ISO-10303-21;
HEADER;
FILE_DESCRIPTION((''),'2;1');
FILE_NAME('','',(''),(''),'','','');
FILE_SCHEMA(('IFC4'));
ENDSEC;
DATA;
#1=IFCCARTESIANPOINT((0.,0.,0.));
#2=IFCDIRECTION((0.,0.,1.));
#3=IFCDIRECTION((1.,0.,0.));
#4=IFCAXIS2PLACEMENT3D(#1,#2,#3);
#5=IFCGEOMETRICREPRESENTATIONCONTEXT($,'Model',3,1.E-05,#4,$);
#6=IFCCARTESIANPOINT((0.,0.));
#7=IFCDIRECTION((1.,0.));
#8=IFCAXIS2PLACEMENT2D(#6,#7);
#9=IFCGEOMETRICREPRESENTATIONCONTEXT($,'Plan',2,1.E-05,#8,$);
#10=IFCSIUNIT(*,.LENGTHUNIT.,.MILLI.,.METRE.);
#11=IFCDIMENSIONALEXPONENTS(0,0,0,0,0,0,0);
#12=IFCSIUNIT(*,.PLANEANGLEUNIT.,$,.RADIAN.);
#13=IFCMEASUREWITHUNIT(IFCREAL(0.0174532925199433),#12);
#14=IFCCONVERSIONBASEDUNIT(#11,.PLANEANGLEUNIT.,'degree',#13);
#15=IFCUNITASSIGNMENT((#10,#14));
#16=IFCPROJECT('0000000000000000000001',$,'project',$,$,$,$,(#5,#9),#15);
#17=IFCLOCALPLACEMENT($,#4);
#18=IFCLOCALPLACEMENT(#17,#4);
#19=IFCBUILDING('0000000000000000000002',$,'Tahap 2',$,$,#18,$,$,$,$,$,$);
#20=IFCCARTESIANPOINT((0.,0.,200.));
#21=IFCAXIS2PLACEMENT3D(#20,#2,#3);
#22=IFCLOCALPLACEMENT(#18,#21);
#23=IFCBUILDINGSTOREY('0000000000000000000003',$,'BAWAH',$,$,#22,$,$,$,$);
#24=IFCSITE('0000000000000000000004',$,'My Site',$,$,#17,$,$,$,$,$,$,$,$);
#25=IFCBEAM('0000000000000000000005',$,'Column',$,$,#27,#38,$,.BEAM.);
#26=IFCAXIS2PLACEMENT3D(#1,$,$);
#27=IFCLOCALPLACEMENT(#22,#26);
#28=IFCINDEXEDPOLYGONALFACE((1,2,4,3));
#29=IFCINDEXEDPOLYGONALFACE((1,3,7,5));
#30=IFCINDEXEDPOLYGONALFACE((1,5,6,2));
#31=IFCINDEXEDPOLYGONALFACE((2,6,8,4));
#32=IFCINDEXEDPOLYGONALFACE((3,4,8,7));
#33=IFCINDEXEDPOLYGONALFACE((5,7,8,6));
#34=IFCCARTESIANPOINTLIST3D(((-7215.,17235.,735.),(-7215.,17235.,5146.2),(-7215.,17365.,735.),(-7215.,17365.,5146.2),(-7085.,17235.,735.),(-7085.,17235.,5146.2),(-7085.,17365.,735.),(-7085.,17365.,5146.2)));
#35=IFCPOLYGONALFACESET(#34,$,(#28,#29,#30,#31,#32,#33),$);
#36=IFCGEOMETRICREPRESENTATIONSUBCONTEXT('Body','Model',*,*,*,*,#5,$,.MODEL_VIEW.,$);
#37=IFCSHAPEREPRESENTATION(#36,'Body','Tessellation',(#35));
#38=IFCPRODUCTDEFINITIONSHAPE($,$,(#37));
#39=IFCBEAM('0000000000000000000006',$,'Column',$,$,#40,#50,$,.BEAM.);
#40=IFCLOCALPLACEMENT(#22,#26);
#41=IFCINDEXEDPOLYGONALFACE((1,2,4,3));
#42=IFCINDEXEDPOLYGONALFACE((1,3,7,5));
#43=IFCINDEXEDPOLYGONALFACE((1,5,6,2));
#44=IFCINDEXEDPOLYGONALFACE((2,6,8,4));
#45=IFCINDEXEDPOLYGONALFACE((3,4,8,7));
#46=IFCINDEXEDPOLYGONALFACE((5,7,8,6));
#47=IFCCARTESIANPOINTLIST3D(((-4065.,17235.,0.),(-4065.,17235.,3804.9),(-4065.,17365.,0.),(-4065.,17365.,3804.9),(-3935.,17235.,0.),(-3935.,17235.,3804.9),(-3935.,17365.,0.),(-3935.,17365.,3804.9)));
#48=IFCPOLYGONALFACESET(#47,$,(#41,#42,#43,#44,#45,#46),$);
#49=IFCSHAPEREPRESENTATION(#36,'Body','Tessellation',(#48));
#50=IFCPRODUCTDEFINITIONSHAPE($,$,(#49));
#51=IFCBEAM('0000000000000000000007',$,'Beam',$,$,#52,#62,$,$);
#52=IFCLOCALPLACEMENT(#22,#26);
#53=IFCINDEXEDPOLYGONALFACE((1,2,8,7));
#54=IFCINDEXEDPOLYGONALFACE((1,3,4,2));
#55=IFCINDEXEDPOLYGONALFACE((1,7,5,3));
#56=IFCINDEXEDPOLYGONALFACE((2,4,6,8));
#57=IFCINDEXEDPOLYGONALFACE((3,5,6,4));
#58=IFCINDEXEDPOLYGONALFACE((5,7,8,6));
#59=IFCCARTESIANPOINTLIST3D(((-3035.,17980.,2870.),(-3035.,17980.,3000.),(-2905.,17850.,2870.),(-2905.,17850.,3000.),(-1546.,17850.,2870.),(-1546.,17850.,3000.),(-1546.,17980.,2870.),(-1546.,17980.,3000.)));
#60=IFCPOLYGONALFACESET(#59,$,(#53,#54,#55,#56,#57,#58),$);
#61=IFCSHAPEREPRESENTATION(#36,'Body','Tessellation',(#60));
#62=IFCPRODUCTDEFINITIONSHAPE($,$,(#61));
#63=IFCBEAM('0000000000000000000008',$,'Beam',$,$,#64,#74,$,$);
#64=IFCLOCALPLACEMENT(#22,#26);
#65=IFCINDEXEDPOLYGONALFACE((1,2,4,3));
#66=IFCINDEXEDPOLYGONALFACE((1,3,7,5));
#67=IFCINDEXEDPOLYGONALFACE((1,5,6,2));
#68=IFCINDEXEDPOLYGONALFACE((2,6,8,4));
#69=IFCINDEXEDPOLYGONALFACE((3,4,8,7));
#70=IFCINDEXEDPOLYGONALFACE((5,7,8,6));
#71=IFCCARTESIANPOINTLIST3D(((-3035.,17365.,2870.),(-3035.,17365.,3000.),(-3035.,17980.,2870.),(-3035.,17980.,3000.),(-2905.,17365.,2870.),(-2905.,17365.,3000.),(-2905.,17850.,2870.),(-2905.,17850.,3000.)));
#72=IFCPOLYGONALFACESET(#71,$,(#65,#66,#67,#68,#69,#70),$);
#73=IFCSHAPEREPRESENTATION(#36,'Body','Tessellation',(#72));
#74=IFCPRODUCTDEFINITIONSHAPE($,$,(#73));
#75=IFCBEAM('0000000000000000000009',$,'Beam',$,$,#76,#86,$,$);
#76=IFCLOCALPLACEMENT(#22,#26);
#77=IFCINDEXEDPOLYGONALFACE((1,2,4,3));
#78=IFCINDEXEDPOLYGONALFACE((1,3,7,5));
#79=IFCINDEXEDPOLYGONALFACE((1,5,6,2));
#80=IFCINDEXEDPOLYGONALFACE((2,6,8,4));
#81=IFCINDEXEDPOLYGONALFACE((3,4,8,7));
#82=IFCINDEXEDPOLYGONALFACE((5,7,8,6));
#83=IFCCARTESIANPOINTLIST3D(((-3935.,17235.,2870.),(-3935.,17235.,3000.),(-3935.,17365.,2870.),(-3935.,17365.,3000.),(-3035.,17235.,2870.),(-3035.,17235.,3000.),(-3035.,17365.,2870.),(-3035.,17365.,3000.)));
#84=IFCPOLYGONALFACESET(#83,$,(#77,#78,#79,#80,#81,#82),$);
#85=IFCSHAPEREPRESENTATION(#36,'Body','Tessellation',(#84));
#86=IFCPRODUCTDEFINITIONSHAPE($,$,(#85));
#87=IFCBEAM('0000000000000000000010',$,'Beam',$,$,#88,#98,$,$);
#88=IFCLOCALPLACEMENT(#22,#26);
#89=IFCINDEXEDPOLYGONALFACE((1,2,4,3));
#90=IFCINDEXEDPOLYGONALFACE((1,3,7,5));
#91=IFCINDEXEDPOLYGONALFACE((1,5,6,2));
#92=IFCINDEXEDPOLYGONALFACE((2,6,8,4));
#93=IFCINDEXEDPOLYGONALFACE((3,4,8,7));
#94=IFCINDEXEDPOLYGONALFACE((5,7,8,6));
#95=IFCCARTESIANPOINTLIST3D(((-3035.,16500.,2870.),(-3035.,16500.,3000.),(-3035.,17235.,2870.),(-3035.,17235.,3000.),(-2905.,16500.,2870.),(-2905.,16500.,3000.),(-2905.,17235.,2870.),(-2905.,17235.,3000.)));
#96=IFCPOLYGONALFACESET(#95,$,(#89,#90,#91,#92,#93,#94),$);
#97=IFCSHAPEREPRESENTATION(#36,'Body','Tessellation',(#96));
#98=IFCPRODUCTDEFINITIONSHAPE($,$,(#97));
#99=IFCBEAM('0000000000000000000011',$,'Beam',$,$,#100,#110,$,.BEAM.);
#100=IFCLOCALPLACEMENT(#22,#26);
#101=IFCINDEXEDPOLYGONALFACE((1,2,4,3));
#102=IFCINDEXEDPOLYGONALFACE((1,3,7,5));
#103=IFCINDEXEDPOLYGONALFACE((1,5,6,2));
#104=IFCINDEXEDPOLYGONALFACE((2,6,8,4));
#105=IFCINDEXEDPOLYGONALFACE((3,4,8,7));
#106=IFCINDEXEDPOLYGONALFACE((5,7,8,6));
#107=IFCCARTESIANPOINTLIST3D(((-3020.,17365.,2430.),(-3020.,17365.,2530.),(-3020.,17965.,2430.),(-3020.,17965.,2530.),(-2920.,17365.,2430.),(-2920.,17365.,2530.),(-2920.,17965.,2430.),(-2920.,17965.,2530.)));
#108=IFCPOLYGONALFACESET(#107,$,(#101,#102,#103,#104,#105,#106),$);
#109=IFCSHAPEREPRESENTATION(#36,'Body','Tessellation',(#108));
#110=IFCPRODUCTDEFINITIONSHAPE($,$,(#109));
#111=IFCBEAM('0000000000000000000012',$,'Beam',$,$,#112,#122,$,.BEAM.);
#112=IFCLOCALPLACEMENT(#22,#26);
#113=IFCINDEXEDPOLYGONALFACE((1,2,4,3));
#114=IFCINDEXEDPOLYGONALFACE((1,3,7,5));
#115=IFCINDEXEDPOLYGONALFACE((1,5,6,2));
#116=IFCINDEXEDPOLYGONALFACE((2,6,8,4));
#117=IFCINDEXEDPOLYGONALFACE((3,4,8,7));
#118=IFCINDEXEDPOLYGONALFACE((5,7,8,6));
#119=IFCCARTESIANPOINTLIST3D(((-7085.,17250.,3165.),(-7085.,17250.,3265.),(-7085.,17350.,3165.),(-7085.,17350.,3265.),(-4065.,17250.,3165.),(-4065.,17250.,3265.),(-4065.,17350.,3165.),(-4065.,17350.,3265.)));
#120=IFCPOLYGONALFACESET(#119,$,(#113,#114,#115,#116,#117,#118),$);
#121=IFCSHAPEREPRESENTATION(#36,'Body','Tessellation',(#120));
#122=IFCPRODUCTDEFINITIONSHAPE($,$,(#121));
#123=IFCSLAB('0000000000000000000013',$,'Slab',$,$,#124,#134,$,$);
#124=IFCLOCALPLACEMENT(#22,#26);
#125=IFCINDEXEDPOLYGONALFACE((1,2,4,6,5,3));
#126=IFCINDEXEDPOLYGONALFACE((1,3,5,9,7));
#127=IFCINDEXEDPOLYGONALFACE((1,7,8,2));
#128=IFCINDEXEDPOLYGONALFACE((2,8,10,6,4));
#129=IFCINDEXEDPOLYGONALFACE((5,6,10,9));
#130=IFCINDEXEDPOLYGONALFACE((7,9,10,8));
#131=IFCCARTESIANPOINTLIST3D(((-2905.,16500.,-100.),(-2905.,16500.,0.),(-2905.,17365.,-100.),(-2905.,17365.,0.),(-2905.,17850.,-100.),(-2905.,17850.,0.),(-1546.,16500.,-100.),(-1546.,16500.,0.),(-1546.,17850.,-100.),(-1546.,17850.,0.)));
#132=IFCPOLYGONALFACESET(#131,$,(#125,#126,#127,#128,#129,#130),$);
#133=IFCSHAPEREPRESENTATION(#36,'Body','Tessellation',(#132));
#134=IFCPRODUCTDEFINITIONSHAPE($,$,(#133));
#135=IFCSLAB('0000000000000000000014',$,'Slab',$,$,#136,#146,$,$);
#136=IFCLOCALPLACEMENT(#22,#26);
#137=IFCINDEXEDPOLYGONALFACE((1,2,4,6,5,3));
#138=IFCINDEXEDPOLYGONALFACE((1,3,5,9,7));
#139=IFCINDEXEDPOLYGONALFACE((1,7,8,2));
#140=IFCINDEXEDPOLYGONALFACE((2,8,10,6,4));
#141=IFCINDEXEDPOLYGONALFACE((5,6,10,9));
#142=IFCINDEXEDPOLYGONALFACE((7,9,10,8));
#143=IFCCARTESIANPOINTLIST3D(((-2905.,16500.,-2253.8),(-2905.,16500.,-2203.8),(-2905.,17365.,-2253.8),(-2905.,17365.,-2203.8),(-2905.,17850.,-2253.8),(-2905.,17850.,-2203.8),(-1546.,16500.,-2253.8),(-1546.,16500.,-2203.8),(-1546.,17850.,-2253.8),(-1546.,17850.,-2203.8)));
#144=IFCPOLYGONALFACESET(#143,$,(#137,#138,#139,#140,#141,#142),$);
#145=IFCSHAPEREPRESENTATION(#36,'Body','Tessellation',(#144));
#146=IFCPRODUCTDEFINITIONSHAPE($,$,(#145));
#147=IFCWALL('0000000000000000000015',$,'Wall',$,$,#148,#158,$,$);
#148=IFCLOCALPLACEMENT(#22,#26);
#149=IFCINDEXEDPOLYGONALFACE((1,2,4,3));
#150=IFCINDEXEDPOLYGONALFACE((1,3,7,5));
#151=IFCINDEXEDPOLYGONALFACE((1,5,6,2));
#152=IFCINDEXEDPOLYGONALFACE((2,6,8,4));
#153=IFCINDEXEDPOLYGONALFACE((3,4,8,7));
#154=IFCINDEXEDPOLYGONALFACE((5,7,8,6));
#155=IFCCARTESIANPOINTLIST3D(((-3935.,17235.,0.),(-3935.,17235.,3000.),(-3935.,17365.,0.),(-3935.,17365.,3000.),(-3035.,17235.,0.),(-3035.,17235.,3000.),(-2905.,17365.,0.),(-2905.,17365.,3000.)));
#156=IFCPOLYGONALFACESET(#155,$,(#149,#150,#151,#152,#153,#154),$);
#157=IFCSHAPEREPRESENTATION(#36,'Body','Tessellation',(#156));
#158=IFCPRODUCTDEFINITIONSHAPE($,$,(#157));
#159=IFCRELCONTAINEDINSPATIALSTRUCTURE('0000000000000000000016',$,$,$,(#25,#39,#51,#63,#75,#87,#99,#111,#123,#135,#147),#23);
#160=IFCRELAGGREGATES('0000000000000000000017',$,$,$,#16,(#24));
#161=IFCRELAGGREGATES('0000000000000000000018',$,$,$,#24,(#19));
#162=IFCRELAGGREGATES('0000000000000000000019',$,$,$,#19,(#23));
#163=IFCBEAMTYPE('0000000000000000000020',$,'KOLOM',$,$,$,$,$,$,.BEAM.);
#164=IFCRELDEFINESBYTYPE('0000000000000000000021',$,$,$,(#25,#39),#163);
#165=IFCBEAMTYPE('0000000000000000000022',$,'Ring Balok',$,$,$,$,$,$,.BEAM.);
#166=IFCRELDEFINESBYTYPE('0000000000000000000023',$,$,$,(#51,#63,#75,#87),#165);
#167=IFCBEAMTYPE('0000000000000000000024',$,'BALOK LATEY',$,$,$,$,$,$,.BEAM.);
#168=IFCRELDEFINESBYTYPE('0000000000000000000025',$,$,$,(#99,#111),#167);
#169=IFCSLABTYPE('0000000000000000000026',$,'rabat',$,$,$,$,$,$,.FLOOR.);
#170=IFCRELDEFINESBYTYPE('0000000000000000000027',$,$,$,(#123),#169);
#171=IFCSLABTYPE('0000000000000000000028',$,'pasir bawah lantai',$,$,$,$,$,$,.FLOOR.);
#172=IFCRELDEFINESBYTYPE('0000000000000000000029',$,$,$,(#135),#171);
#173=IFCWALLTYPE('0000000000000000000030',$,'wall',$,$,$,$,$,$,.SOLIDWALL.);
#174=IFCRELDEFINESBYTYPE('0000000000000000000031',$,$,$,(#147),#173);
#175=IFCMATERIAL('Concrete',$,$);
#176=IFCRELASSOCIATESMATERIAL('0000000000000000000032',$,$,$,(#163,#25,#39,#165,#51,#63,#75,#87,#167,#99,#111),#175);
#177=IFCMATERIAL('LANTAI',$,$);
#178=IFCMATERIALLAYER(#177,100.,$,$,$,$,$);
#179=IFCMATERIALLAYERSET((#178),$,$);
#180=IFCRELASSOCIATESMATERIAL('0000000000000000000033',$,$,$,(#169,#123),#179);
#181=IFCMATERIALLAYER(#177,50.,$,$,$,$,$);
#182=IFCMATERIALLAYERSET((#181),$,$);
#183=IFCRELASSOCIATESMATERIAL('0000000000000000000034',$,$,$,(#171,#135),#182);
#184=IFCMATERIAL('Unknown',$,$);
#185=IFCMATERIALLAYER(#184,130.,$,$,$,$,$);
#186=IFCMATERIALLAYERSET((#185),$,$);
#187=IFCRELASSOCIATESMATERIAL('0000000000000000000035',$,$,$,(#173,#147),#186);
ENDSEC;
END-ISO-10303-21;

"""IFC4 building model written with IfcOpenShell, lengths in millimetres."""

from ifc_helpers import new_model, entity, si_unit, converted_unit, frame, origin_with_axes, origin_2d_with_axis, place, context, subcontext, project, spatial, line, indexed_curve, rectangle, outline, extrude, clip, halfspace, material, layer, layer_set, layer_usage, material_profile, profile_set, profile_usage, type_object, element, save


model = new_model("IFC4")

# Units and contexts
model_context = context("Model", 3, precision=1e-05, world=origin_with_axes())
plan_context = context("Plan", 2, precision=1e-05, world=origin_2d_with_axis())
body_context = subcontext(model_context, "Body", "Model", "MODEL_VIEW")
ifc_project = project(units=[si_unit("LENGTHUNIT", "METRE", prefix="MILLI"), converted_unit("PLANEANGLEUNIT", "degree", entity("IfcReal", 0.0174532925199433), si_unit("PLANEANGLEUNIT", "RADIAN"), dimensions=[0, 0, 0, 0, 0, 0, 0])], contexts=[model_context, plan_context])

# Site, building, storey
site_placement = place(None, origin_with_axes())
site = spatial("IfcSite", under=ifc_project, at=site_placement, Name="My Site")
building_placement = place(site_placement, origin_with_axes())
building = spatial("IfcBuilding", under=site, at=building_placement, Name="Tahap 2")
storey_placement = place(building_placement, frame((0.0, 0.0, 200.0), z_axis=(0.0, 0.0, 1.0), x_axis=(1.0, 0.0, 0.0)))
storey = spatial("IfcBuildingStorey", under=building, at=storey_placement, Name="BAWAH")

# Shared definitions
ifc_material_1 = material(Name="Unknown")

# Beams
ifc_material_2 = material(Name="Concrete")
ifc_material_profile_1 = material_profile(ifc_material_2, rectangle(XDim=130.0, YDim=130.0, kind="CURVE"))
ifc_profile_set_1 = profile_set([ifc_material_profile_1])
beam_type_1 = type_object("IfcBeamType", Name="KOLOM", PredefinedType="BEAM", material=ifc_profile_set_1)
ifc_profile_usage_1 = profile_usage(ifc_profile_set_1, cardinal=5)
beam_1_placement = place(storey_placement, frame((-7150.0, 17300.0, 735.0), z_axis=(0.0, 0.0, 1.0), x_axis=(1.0, 0.0, 0.0)))
element("IfcBeam", 1, at=beam_1_placement, inside=storey, type_object=beam_type_1, material=ifc_profile_usage_1, Name="Column", PredefinedType="BEAM", context=body_context, shape_type="SweptSolid", body=[
    extrude(rectangle(XDim=130.0, YDim=130.0, kind="CURVE"), origin_with_axes(), (0.0, 0.0, 1.0), 4411.2),
])
ifc_profile_usage_2 = profile_usage(ifc_profile_set_1, cardinal=5)
beam_2_placement = place(storey_placement, frame((-4000.0, 17300.0, 0.0), z_axis=(0.0, 0.0, 1.0), x_axis=(1.0, 0.0, 0.0)))
element("IfcBeam", 2, at=beam_2_placement, inside=storey, type_object=beam_type_1, material=ifc_profile_usage_2, Name="Column", PredefinedType="BEAM", context=body_context, shape_type="SweptSolid", body=[
    extrude(rectangle(XDim=130.0, YDim=130.0, kind="CURVE"), origin_with_axes(), (0.0, 0.0, 1.0), 3804.9),
])
ifc_material_profile_2 = material_profile(ifc_material_2, rectangle(XDim=130.0, YDim=130.0))
ifc_profile_set_2 = profile_set([ifc_material_profile_2])
ifc_profile_usage_3 = profile_usage(ifc_profile_set_2, cardinal=9)
beam_type_2 = type_object("IfcBeamType", Name="Ring Balok", PredefinedType="BEAM", material=ifc_profile_set_2)
beam_3_placement = place(storey_placement, frame((-1546.0, 17980.0, 3000.0), z_axis=(-1.0, 0.0, 0.0), x_axis=(0.0, -1.0, 0.0)))
element("IfcBeam", 3, at=beam_3_placement, inside=storey, type_object=beam_type_2, material=ifc_profile_usage_3, Name="Beam", context=body_context, shape_type="Clipping", body=[
    clip(extrude(rectangle(XDim=130.0, YDim=130.0), frame((65.0, -65.0, 0.0), z_axis=(0.0, 0.0, 1.0), x_axis=(1.0, 0.0, 0.0)), (0.0, 0.0, 1.0), 1489.0), halfspace(frame((0.0, -3200.0, 1489.0), z_axis=(0.70711, 0.0, 0.707104), x_axis=(0.0, -1.0, 0.0)), False)),
])
ifc_profile_usage_4 = profile_usage(ifc_profile_set_2, cardinal=9)
beam_4_placement = place(storey_placement, frame((-3035.0, 17980.0, 3000.0), z_axis=(0.0, -1.0, 0.0), x_axis=(1.0, 0.0, 0.0)))
element("IfcBeam", 4, at=beam_4_placement, inside=storey, type_object=beam_type_2, material=ifc_profile_usage_4, Name="Beam", context=body_context, shape_type="Clipping", body=[
    clip(extrude(rectangle(XDim=130.0, YDim=130.0), frame((65.0, -65.0, 0.0), z_axis=(0.0, 0.0, 1.0), x_axis=(1.0, 0.0, 0.0)), (0.0, 0.0, 1.0), 615.0), halfspace(frame((0.0, -3200.0, 0.0), z_axis=(0.707104, 0.0, -0.70711), x_axis=(0.0, -1.0, 0.0)), False)),
])
ifc_profile_usage_5 = profile_usage(ifc_profile_set_2, cardinal=9)
beam_5_placement = place(storey_placement, frame((-3035.0, 17365.0, 3000.0), z_axis=(-1.0, 0.0, 0.0), x_axis=(0.0, -1.0, 0.0)))
element("IfcBeam", 5, at=beam_5_placement, inside=storey, type_object=beam_type_2, material=ifc_profile_usage_5, Name="Beam", context=body_context, shape_type="SweptSolid", body=[
    extrude(rectangle(XDim=130.0, YDim=130.0), frame((65.0, -65.0, 0.0), z_axis=(0.0, 0.0, 1.0), x_axis=(1.0, 0.0, 0.0)), (0.0, 0.0, 1.0), 900.0),
])
ifc_profile_usage_6 = profile_usage(ifc_profile_set_2, cardinal=9)
beam_6_placement = place(storey_placement, frame((-3035.0, 17235.0, 3000.0), z_axis=(0.0, -1.0, 0.0), x_axis=(1.0, 0.0, 0.0)))
element("IfcBeam", 6, at=beam_6_placement, inside=storey, type_object=beam_type_2, material=ifc_profile_usage_6, Name="Beam", context=body_context, shape_type="SweptSolid", body=[
    extrude(rectangle(XDim=130.0, YDim=130.0), frame((65.0, -65.0, 0.0), z_axis=(0.0, 0.0, 1.0), x_axis=(1.0, 0.0, 0.0)), (0.0, 0.0, 1.0), 735.0),
])
ifc_material_profile_3 = material_profile(ifc_material_2, rectangle(XDim=100.0, YDim=100.0))
ifc_profile_set_3 = profile_set([ifc_material_profile_3])
ifc_profile_usage_7 = profile_usage(ifc_profile_set_3, cardinal=2)
beam_type_3 = type_object("IfcBeamType", Name="BALOK LATEY", PredefinedType="BEAM", material=ifc_profile_set_3)
beam_7_placement = place(storey_placement, frame((-2970.0, 17965.0, 2430.0), z_axis=(0.0, -1.0, -0.000003), x_axis=(1.0, 0.0, 0.0)))
element("IfcBeam", 7, at=beam_7_placement, inside=storey, type_object=beam_type_3, material=ifc_profile_usage_7, Name="Beam", PredefinedType="BEAM", context=body_context, shape_type="SweptSolid", body=[
    extrude(rectangle(XDim=100.0, YDim=100.0), frame((0.0, 50.0, 0.0), z_axis=(0.0, 0.0, 1.0), x_axis=(1.0, 0.0, 0.0)), (0.0, 0.0, 1.0), 600.0),
])
ifc_profile_usage_8 = profile_usage(ifc_profile_set_3, cardinal=2)
beam_8_placement = place(storey_placement, frame((-7085.0, 17300.0, 3165.0), z_axis=(1.0, 0.0, 0.0), x_axis=(0.0, 1.0, 0.0)))
element("IfcBeam", 8, at=beam_8_placement, inside=storey, type_object=beam_type_3, material=ifc_profile_usage_8, Name="Beam", PredefinedType="BEAM", context=body_context, shape_type="SweptSolid", body=[
    extrude(rectangle(XDim=100.0, YDim=100.0), frame((0.0, 50.0, 0.0), z_axis=(0.0, 0.0, 1.0), x_axis=(1.0, 0.0, 0.0)), (0.0, 0.0, 1.0), 3020.0),
])

# Slabs
ifc_material_3 = material(Name="LANTAI")
ifc_layer_1 = layer(ifc_material_3, 100.0)
ifc_layer_set_1 = layer_set([ifc_layer_1])
ifc_layer_usage_1 = layer_usage(ifc_layer_set_1, "AXIS3", "NEGATIVE", 0.0)
slab_type_1 = type_object("IfcSlabType", Name="rabat", PredefinedType="FLOOR", material=ifc_layer_set_1)
slab_1_placement = place(storey_placement, frame((-2905.0, 16500.0, 0.0), z_axis=(0.0, 0.0, 1.0), x_axis=(1.0, 0.0, 0.0)))
element("IfcSlab", 9, at=slab_1_placement, inside=storey, type_object=slab_type_1, material=ifc_layer_usage_1, Name="Slab", context=body_context, shape_type="SweptSolid", body=[
    extrude(outline(indexed_curve([(1359.0, 0.0), (0.0, 0.0), (0.0, 865.0), (0.0, 1350.0), (1359.0, 1350.0), (1359.0, 0.0)])), None, (0.0, 0.0, -1.0), 100.0),
])
ifc_layer_2 = layer(ifc_material_3, 50.0)
ifc_layer_set_2 = layer_set([ifc_layer_2])
ifc_layer_usage_2 = layer_usage(ifc_layer_set_2, "AXIS3", "POSITIVE", -50.0)
slab_type_2 = type_object("IfcSlabType", Name="pasir bawah lantai", PredefinedType="FLOOR", material=ifc_layer_set_2)
slab_2_placement = place(storey_placement, frame((-2905.0, 16500.0, -2203.8), z_axis=(0.0, 0.0, 1.0), x_axis=(1.0, 0.0, 0.0)))
element("IfcSlab", 10, at=slab_2_placement, inside=storey, type_object=slab_type_2, material=ifc_layer_usage_2, Name="Slab", context=body_context, shape_type="SweptSolid", body=[
    extrude(outline(indexed_curve([(1359.0, 0.0), (0.0, 0.0), (0.0, 865.0), (0.0, 1350.0), (1359.0, 1350.0), (1359.0, 0.0)])), frame((0.0, 0.0, -50.0), z_axis=(0.0, 0.0, 1.0), x_axis=(1.0, 0.0, 0.0)), (0.0, 0.0, 1.0), 50.0),
])

# Wall
ifc_layer_3 = layer(ifc_material_1, 130.0)
ifc_layer_set_3 = layer_set([ifc_layer_3])
ifc_layer_usage_3 = layer_usage(ifc_layer_set_3, "AXIS2", "POSITIVE", 0.0)
wall_type = type_object("IfcWallType", Name="wall", PredefinedType="SOLIDWALL", material=ifc_layer_set_3)
wall_placement = place(storey_placement, frame((-2905.0, 17365.0, 0.0), z_axis=(0.0, 0.0, 1.0), x_axis=(-1.0, 0.000004, 0.0)))
element("IfcWall", 11, at=wall_placement, inside=storey, type_object=wall_type, material=ifc_layer_usage_3, Name="Wall", context=body_context, shape_type="SweptSolid", body=[
    extrude(outline(indexed_curve([(0.0, 0.0), (130.0, 130.0), (1030.0, 130.0), (1030.0, 0.0)], segments=[line(1, 2, 3, 4, 1)])), origin_with_axes(), (0.0, 0.0, 1.0), 3000.0),
])

save(model, "model.ifc")
